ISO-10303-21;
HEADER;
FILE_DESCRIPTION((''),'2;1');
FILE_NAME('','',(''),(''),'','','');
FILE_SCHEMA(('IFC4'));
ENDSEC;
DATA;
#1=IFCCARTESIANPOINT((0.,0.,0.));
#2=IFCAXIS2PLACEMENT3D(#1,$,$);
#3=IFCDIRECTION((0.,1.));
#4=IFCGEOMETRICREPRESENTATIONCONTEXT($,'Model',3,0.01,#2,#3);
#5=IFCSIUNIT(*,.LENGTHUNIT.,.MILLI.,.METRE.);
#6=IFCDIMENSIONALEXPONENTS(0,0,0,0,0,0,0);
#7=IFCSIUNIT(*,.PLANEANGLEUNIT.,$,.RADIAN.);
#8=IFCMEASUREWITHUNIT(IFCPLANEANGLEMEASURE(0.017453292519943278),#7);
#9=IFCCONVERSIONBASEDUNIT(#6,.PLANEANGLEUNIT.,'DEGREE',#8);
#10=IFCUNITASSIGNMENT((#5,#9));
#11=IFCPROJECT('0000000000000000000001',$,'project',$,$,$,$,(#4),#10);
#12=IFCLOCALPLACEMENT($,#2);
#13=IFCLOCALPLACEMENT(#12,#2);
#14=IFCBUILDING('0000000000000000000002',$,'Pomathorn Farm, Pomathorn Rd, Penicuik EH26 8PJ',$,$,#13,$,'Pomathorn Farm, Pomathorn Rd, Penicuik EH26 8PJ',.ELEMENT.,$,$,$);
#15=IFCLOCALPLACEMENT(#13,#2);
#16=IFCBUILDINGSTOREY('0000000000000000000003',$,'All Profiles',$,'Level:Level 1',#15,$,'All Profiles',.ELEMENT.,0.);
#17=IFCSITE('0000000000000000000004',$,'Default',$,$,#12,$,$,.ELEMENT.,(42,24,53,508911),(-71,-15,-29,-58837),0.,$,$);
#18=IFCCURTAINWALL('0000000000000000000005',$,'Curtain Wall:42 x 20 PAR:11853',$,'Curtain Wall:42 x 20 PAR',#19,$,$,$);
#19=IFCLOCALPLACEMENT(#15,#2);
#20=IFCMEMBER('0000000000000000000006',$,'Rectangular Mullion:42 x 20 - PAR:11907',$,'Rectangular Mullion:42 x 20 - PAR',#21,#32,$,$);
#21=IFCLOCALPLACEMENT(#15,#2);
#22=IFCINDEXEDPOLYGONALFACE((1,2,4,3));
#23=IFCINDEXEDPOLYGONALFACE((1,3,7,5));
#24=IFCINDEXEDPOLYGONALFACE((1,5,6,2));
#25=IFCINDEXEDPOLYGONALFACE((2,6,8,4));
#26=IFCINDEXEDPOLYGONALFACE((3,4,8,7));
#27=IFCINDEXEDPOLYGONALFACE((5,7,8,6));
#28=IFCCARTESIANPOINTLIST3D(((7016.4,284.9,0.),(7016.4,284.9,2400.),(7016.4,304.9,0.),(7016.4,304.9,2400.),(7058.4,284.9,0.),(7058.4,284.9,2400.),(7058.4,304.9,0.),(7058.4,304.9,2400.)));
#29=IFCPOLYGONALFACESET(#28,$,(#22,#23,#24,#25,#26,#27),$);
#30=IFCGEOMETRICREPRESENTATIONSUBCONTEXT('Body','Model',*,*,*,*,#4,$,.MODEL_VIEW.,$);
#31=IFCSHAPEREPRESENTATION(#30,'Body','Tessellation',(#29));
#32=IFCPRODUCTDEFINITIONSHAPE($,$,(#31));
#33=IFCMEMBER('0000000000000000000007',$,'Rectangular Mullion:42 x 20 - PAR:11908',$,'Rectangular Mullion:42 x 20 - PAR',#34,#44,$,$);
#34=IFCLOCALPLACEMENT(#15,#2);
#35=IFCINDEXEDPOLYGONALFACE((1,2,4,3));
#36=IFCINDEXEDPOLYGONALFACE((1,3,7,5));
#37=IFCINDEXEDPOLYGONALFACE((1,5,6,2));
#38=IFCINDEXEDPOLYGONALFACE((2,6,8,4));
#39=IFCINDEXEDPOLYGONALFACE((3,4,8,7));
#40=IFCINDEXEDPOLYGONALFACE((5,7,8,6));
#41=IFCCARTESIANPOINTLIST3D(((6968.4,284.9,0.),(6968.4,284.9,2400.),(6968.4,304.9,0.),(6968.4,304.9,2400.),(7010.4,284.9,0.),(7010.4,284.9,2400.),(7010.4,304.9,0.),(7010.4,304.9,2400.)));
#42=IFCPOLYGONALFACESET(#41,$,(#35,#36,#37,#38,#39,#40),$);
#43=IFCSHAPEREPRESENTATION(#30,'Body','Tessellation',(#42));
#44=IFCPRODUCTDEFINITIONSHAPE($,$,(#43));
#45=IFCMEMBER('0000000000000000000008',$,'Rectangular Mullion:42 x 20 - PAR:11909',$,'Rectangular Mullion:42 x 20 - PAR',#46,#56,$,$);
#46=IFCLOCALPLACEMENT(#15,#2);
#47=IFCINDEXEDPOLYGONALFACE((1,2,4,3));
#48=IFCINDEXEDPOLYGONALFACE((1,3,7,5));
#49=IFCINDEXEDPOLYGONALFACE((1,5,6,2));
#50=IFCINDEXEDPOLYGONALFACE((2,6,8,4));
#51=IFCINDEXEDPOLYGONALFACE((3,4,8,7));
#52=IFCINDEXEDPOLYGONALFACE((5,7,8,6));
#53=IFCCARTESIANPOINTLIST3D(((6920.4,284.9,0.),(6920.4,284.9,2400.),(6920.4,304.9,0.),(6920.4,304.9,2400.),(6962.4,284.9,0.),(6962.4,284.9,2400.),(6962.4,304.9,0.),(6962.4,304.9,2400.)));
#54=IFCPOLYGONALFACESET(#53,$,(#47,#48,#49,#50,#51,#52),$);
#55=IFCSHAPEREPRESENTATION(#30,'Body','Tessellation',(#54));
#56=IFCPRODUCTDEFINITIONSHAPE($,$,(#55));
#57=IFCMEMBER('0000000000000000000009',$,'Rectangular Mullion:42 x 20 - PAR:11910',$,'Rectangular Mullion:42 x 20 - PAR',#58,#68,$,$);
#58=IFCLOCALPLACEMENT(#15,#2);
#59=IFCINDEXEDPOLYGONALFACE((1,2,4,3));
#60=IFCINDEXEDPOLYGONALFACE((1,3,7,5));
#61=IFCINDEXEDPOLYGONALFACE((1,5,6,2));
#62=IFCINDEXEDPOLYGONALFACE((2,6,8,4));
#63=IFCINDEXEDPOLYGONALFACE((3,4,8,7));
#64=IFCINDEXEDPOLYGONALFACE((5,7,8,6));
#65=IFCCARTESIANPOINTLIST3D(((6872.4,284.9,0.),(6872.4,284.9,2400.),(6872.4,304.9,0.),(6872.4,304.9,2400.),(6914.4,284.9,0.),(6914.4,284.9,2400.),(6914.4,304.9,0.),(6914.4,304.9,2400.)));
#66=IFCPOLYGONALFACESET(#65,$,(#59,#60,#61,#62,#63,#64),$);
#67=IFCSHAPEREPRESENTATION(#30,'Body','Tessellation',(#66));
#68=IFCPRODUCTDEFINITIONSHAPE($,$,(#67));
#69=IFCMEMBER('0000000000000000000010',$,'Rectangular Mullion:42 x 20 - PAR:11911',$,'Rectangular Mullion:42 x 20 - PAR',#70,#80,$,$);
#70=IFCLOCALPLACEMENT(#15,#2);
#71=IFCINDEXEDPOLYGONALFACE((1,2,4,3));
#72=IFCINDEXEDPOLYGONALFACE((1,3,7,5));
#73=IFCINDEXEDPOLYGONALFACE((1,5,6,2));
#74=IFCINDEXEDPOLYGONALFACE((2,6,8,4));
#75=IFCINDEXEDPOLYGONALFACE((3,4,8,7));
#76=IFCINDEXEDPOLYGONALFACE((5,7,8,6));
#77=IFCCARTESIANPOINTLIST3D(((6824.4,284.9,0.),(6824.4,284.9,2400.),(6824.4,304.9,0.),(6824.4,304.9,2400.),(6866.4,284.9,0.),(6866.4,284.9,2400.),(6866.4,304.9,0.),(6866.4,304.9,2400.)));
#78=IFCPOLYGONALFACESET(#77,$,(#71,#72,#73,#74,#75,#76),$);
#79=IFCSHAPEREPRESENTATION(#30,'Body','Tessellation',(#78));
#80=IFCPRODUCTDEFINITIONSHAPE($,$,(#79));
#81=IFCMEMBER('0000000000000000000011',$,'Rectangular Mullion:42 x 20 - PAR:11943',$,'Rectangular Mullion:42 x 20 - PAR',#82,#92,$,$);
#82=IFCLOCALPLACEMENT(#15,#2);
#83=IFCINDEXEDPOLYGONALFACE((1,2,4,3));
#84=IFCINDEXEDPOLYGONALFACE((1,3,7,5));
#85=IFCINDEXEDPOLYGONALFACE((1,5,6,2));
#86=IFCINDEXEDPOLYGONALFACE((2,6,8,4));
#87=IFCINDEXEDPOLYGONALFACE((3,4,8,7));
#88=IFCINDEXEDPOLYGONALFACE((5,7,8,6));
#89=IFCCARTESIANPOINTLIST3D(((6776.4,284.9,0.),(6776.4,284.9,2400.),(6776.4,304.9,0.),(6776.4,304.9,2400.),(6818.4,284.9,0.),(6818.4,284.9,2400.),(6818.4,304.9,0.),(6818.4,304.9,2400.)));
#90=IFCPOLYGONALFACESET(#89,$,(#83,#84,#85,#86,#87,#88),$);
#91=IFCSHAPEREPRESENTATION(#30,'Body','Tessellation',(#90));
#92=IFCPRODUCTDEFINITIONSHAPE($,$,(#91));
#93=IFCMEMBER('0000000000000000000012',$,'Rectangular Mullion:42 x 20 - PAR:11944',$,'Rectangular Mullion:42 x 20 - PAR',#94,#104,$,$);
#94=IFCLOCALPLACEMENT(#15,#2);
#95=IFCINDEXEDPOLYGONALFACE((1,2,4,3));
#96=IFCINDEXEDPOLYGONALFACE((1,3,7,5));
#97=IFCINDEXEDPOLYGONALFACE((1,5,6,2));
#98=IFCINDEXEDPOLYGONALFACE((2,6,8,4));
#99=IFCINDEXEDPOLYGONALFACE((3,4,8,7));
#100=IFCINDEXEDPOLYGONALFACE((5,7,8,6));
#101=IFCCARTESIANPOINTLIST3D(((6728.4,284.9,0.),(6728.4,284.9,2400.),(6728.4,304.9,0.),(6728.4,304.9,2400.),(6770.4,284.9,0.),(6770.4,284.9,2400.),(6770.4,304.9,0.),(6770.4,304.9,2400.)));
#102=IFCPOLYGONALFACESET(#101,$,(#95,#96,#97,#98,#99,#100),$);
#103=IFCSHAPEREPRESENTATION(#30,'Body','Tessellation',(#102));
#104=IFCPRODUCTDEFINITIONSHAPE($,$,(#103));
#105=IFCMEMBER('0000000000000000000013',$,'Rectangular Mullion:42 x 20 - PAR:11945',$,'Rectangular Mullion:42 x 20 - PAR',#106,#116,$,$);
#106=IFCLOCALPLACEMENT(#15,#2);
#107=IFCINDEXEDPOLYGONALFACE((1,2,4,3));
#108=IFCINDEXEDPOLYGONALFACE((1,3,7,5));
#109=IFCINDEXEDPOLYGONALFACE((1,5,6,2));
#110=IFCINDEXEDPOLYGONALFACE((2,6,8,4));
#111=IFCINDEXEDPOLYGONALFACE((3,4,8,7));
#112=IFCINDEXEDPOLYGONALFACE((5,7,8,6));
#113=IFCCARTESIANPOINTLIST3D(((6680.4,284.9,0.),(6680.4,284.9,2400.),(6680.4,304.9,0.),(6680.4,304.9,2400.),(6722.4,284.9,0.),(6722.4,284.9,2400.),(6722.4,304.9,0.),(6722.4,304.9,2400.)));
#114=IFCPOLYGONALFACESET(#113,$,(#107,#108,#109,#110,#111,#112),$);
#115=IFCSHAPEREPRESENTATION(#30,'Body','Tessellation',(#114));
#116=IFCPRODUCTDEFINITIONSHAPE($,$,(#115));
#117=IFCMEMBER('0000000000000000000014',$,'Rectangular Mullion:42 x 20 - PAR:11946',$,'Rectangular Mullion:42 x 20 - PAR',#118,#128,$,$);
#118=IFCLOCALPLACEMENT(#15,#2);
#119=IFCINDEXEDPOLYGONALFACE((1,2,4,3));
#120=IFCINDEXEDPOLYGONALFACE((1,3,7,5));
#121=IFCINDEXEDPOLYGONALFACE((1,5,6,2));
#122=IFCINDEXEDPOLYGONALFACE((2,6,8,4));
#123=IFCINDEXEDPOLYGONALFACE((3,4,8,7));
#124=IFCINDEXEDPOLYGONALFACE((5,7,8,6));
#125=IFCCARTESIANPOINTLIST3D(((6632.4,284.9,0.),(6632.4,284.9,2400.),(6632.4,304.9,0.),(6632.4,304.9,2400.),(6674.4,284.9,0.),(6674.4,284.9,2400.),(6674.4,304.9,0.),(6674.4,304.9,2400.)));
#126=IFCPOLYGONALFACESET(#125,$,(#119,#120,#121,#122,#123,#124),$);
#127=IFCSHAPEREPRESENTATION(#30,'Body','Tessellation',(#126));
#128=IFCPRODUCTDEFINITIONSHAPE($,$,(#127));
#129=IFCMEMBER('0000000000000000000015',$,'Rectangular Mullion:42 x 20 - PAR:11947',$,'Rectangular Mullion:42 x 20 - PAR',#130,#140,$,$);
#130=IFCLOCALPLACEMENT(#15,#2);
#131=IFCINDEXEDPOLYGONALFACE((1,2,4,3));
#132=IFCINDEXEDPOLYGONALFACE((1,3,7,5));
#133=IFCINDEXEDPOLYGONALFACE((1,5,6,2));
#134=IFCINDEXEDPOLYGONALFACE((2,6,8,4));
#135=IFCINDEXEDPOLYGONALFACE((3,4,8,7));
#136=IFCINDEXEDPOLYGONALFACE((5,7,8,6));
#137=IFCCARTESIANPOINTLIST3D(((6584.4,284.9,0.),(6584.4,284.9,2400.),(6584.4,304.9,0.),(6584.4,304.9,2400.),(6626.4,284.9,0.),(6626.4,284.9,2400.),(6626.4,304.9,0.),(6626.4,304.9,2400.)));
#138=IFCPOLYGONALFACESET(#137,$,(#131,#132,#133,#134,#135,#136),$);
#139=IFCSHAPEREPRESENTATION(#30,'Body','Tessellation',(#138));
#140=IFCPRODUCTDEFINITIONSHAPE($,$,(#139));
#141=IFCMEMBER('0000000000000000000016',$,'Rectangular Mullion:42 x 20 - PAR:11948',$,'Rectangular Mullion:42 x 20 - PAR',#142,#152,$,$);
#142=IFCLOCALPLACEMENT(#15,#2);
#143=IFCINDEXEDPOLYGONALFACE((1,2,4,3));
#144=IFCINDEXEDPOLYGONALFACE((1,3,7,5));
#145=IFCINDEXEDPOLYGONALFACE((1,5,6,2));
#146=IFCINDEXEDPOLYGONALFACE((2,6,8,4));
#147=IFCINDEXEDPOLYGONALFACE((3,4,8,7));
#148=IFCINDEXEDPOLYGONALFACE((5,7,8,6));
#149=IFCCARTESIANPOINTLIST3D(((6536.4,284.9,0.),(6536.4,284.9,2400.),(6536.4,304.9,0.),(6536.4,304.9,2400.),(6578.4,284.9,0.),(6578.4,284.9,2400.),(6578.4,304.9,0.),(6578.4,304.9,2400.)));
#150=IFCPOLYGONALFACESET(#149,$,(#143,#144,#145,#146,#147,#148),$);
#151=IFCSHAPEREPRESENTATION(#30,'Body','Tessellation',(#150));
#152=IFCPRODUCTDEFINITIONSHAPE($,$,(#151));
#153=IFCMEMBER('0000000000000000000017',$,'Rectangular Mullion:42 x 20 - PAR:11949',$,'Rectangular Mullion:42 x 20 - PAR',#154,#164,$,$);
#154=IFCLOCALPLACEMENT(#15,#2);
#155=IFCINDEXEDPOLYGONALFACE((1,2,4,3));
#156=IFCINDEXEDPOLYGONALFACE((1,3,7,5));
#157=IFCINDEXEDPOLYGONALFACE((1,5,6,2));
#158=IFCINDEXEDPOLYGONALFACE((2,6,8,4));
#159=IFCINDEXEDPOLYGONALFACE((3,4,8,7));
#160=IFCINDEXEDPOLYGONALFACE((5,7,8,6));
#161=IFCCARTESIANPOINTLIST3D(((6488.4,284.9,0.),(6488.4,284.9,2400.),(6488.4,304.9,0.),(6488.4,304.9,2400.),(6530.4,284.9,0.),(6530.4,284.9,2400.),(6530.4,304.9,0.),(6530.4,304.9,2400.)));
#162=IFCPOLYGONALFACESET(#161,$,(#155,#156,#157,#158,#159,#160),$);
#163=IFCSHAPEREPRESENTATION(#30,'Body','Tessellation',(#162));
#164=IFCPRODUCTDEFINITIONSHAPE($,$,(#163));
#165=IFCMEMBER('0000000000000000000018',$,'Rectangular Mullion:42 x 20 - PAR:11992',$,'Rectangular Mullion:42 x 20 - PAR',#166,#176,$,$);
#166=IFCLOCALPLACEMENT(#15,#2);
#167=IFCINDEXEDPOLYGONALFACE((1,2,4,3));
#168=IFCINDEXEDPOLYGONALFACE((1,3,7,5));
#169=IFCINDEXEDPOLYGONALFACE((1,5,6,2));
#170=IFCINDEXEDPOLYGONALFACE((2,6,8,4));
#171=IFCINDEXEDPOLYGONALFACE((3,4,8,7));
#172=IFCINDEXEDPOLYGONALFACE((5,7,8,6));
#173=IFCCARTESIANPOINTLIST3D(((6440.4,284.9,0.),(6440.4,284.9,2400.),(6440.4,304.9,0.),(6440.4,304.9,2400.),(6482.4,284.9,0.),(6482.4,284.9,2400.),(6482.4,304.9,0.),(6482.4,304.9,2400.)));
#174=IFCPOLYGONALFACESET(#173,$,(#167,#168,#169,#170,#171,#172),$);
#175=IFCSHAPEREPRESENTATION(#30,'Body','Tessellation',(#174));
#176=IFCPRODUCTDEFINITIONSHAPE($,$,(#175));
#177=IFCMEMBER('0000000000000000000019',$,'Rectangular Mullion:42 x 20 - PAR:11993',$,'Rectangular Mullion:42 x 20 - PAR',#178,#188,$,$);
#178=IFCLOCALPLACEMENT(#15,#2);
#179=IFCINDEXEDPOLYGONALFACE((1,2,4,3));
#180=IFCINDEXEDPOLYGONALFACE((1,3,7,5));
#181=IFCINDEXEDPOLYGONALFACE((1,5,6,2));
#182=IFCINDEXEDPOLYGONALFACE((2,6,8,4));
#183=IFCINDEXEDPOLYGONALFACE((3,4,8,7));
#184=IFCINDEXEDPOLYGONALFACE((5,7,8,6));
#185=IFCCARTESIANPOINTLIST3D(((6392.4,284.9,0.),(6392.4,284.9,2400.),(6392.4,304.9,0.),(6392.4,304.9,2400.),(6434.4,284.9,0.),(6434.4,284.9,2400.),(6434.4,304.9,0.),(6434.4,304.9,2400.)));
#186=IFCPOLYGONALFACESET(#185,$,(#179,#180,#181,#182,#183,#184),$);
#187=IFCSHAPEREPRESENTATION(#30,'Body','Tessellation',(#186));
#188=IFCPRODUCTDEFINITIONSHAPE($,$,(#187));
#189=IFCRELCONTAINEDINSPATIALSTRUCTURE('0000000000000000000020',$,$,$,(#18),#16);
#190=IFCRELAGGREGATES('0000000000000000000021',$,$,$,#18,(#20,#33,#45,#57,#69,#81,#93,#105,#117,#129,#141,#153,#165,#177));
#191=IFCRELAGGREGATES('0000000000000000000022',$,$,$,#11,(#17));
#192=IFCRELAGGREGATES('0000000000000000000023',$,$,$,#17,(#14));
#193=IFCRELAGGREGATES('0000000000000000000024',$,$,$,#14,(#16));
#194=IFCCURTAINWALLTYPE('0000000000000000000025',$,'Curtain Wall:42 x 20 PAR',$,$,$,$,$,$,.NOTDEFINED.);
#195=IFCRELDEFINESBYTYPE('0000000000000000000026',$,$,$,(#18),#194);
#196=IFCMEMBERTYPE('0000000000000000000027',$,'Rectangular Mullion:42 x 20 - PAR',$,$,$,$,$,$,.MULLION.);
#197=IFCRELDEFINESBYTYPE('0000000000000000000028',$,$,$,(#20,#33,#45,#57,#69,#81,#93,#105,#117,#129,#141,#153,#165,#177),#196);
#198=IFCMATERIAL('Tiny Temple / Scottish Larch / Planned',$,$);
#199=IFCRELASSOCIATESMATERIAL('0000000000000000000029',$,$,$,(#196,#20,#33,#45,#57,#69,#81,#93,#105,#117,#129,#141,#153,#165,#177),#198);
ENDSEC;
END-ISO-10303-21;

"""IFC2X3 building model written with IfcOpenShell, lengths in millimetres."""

from ifc_helpers import new_model, entity, si_unit, converted_unit, direction, frame, frame_2d, origin, place, context, subcontext, project, spatial, rectangle, extrude, source, transform, mapped, material, type_object, type_shapes, element, aggregate, save


model = new_model("IFC2X3")

# Units and contexts
model_context = context("Model", 3, precision=0.01, world=origin(), true_north=direction((0.0, 1.0)))
body_context = subcontext(model_context, "Body", "Model", "MODEL_VIEW")
ifc_project = project(units=[si_unit("LENGTHUNIT", "METRE", prefix="MILLI"), converted_unit("PLANEANGLEUNIT", "DEGREE", entity("IfcPlaneAngleMeasure", 0.017453292519943278), si_unit("PLANEANGLEUNIT", "RADIAN"), dimensions=[0, 0, 0, 0, 0, 0, 0])], contexts=[model_context])

# Site, building, storey
site_placement = place(None, origin())
site = spatial("IfcSite", under=ifc_project, at=site_placement, Name="Default", CompositionType="ELEMENT", RefLatitude=(42, 24, 53, 508911), RefLongitude=(-71, -15, -29, -58837), RefElevation=0.0)
building_placement = place(site_placement, origin())
building = spatial("IfcBuilding", under=site, at=building_placement, Name="Pomathorn Farm, Pomathorn Rd, Penicuik EH26 8PJ", LongName="Pomathorn Farm, Pomathorn Rd, Penicuik EH26 8PJ", CompositionType="ELEMENT")
storey_placement = place(building_placement, origin())
storey = spatial("IfcBuildingStorey", under=building, at=storey_placement, Name="All Profiles", ObjectType="Level:Level 1", LongName="All Profiles", CompositionType="ELEMENT", Elevation=0.0)

# Curtain wall, members
curtain_wall_type = type_object("IfcCurtainWallType", Name="Curtain Wall:42 x 20 PAR", PredefinedType="NOTDEFINED")
curtain_wall_placement = place(storey_placement, origin())
curtain_wall = element("IfcCurtainWall", 1, at=curtain_wall_placement, inside=storey, type_object=curtain_wall_type, Name="Curtain Wall:42 x 20 PAR:11853", ObjectType="Curtain Wall:42 x 20 PAR")
ifc_material = material(Name="Tiny Temple / Scottish Larch / Planned")
member_type = type_object("IfcMemberType", Name="Rectangular Mullion:42 x 20 - PAR", PredefinedType="MULLION", material=ifc_material)
shared_shape = source(origin(), body_context, "Body", "SweptSolid", [
    extrude(rectangle(XDim=20.0, YDim=42.0, at=frame_2d((0.0, 0.0), x_axis=(1.0, 0.0))), frame((-21.0, -10.0, -2400.0), z_axis=(0.0, 0.0, 1.0), x_axis=(0.0, 1.0, 0.0)), (0.0, 0.0, 1.0), 2400.0),
])
type_shapes(member_type, [shared_shape])
member_1_placement = place(curtain_wall_placement, frame((7058.4, 284.9, 0.0), z_axis=(0.0, 0.0, -1.0), x_axis=(1.0, 0.0, 0.0)))
member_1 = element("IfcMember", 2, at=member_1_placement, type_object=member_type, material=ifc_material, Name="Rectangular Mullion:42 x 20 - PAR:11907", ObjectType="Rectangular Mullion:42 x 20 - PAR", context=body_context, shape_type="MappedRepresentation", body=[
    mapped(shared_shape, transform((0.0, 0.0, 0.0), scale=1.0)),
])
member_2_placement = place(curtain_wall_placement, frame((7010.4, 284.9, 0.0), z_axis=(0.0, 0.0, -1.0), x_axis=(1.0, 0.0, 0.0)))
member_2 = element("IfcMember", 3, at=member_2_placement, type_object=member_type, material=ifc_material, Name="Rectangular Mullion:42 x 20 - PAR:11908", ObjectType="Rectangular Mullion:42 x 20 - PAR", context=body_context, shape_type="MappedRepresentation", body=[
    mapped(shared_shape, transform((0.0, 0.0, 0.0), scale=1.0)),
])
member_3_placement = place(curtain_wall_placement, frame((6962.4, 284.9, 0.0), z_axis=(0.0, 0.0, -1.0), x_axis=(1.0, 0.0, 0.0)))
member_3 = element("IfcMember", 4, at=member_3_placement, type_object=member_type, material=ifc_material, Name="Rectangular Mullion:42 x 20 - PAR:11909", ObjectType="Rectangular Mullion:42 x 20 - PAR", context=body_context, shape_type="MappedRepresentation", body=[
    mapped(shared_shape, transform((0.0, 0.0, 0.0), scale=1.0)),
])
member_4_placement = place(curtain_wall_placement, frame((6914.4, 284.9, 0.0), z_axis=(0.0, 0.0, -1.0), x_axis=(1.0, 0.0, 0.0)))
member_4 = element("IfcMember", 5, at=member_4_placement, type_object=member_type, material=ifc_material, Name="Rectangular Mullion:42 x 20 - PAR:11910", ObjectType="Rectangular Mullion:42 x 20 - PAR", context=body_context, shape_type="MappedRepresentation", body=[
    mapped(shared_shape, transform((0.0, 0.0, 0.0), scale=1.0)),
])
member_5_placement = place(curtain_wall_placement, frame((6866.4, 284.9, 0.0), z_axis=(0.0, 0.0, -1.0), x_axis=(1.0, 0.0, 0.0)))
member_5 = element("IfcMember", 6, at=member_5_placement, type_object=member_type, material=ifc_material, Name="Rectangular Mullion:42 x 20 - PAR:11911", ObjectType="Rectangular Mullion:42 x 20 - PAR", context=body_context, shape_type="MappedRepresentation", body=[
    mapped(shared_shape, transform((0.0, 0.0, 0.0), scale=1.0)),
])
member_6_placement = place(curtain_wall_placement, frame((6818.4, 284.9, 0.0), z_axis=(0.0, 0.0, -1.0), x_axis=(1.0, 0.0, 0.0)))
member_6 = element("IfcMember", 7, at=member_6_placement, type_object=member_type, material=ifc_material, Name="Rectangular Mullion:42 x 20 - PAR:11943", ObjectType="Rectangular Mullion:42 x 20 - PAR", context=body_context, shape_type="MappedRepresentation", body=[
    mapped(shared_shape, transform((0.0, 0.0, 0.0), scale=1.0)),
])
member_7_placement = place(curtain_wall_placement, frame((6770.4, 284.9, 0.0), z_axis=(0.0, 0.0, -1.0), x_axis=(1.0, 0.0, 0.0)))
member_7 = element("IfcMember", 8, at=member_7_placement, type_object=member_type, material=ifc_material, Name="Rectangular Mullion:42 x 20 - PAR:11944", ObjectType="Rectangular Mullion:42 x 20 - PAR", context=body_context, shape_type="MappedRepresentation", body=[
    mapped(shared_shape, transform((0.0, 0.0, 0.0), scale=1.0)),
])
member_8_placement = place(curtain_wall_placement, frame((6722.4, 284.9, 0.0), z_axis=(0.0, 0.0, -1.0), x_axis=(1.0, 0.0, 0.0)))
member_8 = element("IfcMember", 9, at=member_8_placement, type_object=member_type, material=ifc_material, Name="Rectangular Mullion:42 x 20 - PAR:11945", ObjectType="Rectangular Mullion:42 x 20 - PAR", context=body_context, shape_type="MappedRepresentation", body=[
    mapped(shared_shape, transform((0.0, 0.0, 0.0), scale=1.0)),
])
member_9_placement = place(curtain_wall_placement, frame((6674.4, 284.9, 0.0), z_axis=(0.0, 0.0, -1.0), x_axis=(1.0, 0.0, 0.0)))
member_9 = element("IfcMember", 10, at=member_9_placement, type_object=member_type, material=ifc_material, Name="Rectangular Mullion:42 x 20 - PAR:11946", ObjectType="Rectangular Mullion:42 x 20 - PAR", context=body_context, shape_type="MappedRepresentation", body=[
    mapped(shared_shape, transform((0.0, 0.0, 0.0), scale=1.0)),
])
member_10_placement = place(curtain_wall_placement, frame((6626.4, 284.9, 0.0), z_axis=(0.0, 0.0, -1.0), x_axis=(1.0, 0.0, 0.0)))
member_10 = element("IfcMember", 11, at=member_10_placement, type_object=member_type, material=ifc_material, Name="Rectangular Mullion:42 x 20 - PAR:11947", ObjectType="Rectangular Mullion:42 x 20 - PAR", context=body_context, shape_type="MappedRepresentation", body=[
    mapped(shared_shape, transform((0.0, 0.0, 0.0), scale=1.0)),
])
member_11_placement = place(curtain_wall_placement, frame((6578.4, 284.9, 0.0), z_axis=(0.0, 0.0, -1.0), x_axis=(1.0, 0.0, 0.0)))
member_11 = element("IfcMember", 12, at=member_11_placement, type_object=member_type, material=ifc_material, Name="Rectangular Mullion:42 x 20 - PAR:11948", ObjectType="Rectangular Mullion:42 x 20 - PAR", context=body_context, shape_type="MappedRepresentation", body=[
    mapped(shared_shape, transform((0.0, 0.0, 0.0), scale=1.0)),
])
member_12_placement = place(curtain_wall_placement, frame((6530.4, 284.9, 0.0), z_axis=(0.0, 0.0, -1.0), x_axis=(1.0, 0.0, 0.0)))
member_12 = element("IfcMember", 13, at=member_12_placement, type_object=member_type, material=ifc_material, Name="Rectangular Mullion:42 x 20 - PAR:11949", ObjectType="Rectangular Mullion:42 x 20 - PAR", context=body_context, shape_type="MappedRepresentation", body=[
    mapped(shared_shape, transform((0.0, 0.0, 0.0), scale=1.0)),
])
member_13_placement = place(curtain_wall_placement, frame((6482.4, 284.9, 0.0), z_axis=(0.0, 0.0, -1.0), x_axis=(1.0, 0.0, 0.0)))
member_13 = element("IfcMember", 14, at=member_13_placement, type_object=member_type, material=ifc_material, Name="Rectangular Mullion:42 x 20 - PAR:11992", ObjectType="Rectangular Mullion:42 x 20 - PAR", context=body_context, shape_type="MappedRepresentation", body=[
    mapped(shared_shape, transform((0.0, 0.0, 0.0), scale=1.0)),
])
member_14_placement = place(curtain_wall_placement, frame((6434.4, 284.9, 0.0), z_axis=(0.0, 0.0, -1.0), x_axis=(1.0, 0.0, 0.0)))
member_14 = element("IfcMember", 15, at=member_14_placement, type_object=member_type, material=ifc_material, Name="Rectangular Mullion:42 x 20 - PAR:11993", ObjectType="Rectangular Mullion:42 x 20 - PAR", context=body_context, shape_type="MappedRepresentation", body=[
    mapped(shared_shape, transform((0.0, 0.0, 0.0), scale=1.0)),
])
aggregate(curtain_wall, [member_1, member_2, member_3, member_4, member_5, member_6, member_7, member_8, member_9, member_10, member_11, member_12, member_13, member_14])

save(model, "model.ifc")
